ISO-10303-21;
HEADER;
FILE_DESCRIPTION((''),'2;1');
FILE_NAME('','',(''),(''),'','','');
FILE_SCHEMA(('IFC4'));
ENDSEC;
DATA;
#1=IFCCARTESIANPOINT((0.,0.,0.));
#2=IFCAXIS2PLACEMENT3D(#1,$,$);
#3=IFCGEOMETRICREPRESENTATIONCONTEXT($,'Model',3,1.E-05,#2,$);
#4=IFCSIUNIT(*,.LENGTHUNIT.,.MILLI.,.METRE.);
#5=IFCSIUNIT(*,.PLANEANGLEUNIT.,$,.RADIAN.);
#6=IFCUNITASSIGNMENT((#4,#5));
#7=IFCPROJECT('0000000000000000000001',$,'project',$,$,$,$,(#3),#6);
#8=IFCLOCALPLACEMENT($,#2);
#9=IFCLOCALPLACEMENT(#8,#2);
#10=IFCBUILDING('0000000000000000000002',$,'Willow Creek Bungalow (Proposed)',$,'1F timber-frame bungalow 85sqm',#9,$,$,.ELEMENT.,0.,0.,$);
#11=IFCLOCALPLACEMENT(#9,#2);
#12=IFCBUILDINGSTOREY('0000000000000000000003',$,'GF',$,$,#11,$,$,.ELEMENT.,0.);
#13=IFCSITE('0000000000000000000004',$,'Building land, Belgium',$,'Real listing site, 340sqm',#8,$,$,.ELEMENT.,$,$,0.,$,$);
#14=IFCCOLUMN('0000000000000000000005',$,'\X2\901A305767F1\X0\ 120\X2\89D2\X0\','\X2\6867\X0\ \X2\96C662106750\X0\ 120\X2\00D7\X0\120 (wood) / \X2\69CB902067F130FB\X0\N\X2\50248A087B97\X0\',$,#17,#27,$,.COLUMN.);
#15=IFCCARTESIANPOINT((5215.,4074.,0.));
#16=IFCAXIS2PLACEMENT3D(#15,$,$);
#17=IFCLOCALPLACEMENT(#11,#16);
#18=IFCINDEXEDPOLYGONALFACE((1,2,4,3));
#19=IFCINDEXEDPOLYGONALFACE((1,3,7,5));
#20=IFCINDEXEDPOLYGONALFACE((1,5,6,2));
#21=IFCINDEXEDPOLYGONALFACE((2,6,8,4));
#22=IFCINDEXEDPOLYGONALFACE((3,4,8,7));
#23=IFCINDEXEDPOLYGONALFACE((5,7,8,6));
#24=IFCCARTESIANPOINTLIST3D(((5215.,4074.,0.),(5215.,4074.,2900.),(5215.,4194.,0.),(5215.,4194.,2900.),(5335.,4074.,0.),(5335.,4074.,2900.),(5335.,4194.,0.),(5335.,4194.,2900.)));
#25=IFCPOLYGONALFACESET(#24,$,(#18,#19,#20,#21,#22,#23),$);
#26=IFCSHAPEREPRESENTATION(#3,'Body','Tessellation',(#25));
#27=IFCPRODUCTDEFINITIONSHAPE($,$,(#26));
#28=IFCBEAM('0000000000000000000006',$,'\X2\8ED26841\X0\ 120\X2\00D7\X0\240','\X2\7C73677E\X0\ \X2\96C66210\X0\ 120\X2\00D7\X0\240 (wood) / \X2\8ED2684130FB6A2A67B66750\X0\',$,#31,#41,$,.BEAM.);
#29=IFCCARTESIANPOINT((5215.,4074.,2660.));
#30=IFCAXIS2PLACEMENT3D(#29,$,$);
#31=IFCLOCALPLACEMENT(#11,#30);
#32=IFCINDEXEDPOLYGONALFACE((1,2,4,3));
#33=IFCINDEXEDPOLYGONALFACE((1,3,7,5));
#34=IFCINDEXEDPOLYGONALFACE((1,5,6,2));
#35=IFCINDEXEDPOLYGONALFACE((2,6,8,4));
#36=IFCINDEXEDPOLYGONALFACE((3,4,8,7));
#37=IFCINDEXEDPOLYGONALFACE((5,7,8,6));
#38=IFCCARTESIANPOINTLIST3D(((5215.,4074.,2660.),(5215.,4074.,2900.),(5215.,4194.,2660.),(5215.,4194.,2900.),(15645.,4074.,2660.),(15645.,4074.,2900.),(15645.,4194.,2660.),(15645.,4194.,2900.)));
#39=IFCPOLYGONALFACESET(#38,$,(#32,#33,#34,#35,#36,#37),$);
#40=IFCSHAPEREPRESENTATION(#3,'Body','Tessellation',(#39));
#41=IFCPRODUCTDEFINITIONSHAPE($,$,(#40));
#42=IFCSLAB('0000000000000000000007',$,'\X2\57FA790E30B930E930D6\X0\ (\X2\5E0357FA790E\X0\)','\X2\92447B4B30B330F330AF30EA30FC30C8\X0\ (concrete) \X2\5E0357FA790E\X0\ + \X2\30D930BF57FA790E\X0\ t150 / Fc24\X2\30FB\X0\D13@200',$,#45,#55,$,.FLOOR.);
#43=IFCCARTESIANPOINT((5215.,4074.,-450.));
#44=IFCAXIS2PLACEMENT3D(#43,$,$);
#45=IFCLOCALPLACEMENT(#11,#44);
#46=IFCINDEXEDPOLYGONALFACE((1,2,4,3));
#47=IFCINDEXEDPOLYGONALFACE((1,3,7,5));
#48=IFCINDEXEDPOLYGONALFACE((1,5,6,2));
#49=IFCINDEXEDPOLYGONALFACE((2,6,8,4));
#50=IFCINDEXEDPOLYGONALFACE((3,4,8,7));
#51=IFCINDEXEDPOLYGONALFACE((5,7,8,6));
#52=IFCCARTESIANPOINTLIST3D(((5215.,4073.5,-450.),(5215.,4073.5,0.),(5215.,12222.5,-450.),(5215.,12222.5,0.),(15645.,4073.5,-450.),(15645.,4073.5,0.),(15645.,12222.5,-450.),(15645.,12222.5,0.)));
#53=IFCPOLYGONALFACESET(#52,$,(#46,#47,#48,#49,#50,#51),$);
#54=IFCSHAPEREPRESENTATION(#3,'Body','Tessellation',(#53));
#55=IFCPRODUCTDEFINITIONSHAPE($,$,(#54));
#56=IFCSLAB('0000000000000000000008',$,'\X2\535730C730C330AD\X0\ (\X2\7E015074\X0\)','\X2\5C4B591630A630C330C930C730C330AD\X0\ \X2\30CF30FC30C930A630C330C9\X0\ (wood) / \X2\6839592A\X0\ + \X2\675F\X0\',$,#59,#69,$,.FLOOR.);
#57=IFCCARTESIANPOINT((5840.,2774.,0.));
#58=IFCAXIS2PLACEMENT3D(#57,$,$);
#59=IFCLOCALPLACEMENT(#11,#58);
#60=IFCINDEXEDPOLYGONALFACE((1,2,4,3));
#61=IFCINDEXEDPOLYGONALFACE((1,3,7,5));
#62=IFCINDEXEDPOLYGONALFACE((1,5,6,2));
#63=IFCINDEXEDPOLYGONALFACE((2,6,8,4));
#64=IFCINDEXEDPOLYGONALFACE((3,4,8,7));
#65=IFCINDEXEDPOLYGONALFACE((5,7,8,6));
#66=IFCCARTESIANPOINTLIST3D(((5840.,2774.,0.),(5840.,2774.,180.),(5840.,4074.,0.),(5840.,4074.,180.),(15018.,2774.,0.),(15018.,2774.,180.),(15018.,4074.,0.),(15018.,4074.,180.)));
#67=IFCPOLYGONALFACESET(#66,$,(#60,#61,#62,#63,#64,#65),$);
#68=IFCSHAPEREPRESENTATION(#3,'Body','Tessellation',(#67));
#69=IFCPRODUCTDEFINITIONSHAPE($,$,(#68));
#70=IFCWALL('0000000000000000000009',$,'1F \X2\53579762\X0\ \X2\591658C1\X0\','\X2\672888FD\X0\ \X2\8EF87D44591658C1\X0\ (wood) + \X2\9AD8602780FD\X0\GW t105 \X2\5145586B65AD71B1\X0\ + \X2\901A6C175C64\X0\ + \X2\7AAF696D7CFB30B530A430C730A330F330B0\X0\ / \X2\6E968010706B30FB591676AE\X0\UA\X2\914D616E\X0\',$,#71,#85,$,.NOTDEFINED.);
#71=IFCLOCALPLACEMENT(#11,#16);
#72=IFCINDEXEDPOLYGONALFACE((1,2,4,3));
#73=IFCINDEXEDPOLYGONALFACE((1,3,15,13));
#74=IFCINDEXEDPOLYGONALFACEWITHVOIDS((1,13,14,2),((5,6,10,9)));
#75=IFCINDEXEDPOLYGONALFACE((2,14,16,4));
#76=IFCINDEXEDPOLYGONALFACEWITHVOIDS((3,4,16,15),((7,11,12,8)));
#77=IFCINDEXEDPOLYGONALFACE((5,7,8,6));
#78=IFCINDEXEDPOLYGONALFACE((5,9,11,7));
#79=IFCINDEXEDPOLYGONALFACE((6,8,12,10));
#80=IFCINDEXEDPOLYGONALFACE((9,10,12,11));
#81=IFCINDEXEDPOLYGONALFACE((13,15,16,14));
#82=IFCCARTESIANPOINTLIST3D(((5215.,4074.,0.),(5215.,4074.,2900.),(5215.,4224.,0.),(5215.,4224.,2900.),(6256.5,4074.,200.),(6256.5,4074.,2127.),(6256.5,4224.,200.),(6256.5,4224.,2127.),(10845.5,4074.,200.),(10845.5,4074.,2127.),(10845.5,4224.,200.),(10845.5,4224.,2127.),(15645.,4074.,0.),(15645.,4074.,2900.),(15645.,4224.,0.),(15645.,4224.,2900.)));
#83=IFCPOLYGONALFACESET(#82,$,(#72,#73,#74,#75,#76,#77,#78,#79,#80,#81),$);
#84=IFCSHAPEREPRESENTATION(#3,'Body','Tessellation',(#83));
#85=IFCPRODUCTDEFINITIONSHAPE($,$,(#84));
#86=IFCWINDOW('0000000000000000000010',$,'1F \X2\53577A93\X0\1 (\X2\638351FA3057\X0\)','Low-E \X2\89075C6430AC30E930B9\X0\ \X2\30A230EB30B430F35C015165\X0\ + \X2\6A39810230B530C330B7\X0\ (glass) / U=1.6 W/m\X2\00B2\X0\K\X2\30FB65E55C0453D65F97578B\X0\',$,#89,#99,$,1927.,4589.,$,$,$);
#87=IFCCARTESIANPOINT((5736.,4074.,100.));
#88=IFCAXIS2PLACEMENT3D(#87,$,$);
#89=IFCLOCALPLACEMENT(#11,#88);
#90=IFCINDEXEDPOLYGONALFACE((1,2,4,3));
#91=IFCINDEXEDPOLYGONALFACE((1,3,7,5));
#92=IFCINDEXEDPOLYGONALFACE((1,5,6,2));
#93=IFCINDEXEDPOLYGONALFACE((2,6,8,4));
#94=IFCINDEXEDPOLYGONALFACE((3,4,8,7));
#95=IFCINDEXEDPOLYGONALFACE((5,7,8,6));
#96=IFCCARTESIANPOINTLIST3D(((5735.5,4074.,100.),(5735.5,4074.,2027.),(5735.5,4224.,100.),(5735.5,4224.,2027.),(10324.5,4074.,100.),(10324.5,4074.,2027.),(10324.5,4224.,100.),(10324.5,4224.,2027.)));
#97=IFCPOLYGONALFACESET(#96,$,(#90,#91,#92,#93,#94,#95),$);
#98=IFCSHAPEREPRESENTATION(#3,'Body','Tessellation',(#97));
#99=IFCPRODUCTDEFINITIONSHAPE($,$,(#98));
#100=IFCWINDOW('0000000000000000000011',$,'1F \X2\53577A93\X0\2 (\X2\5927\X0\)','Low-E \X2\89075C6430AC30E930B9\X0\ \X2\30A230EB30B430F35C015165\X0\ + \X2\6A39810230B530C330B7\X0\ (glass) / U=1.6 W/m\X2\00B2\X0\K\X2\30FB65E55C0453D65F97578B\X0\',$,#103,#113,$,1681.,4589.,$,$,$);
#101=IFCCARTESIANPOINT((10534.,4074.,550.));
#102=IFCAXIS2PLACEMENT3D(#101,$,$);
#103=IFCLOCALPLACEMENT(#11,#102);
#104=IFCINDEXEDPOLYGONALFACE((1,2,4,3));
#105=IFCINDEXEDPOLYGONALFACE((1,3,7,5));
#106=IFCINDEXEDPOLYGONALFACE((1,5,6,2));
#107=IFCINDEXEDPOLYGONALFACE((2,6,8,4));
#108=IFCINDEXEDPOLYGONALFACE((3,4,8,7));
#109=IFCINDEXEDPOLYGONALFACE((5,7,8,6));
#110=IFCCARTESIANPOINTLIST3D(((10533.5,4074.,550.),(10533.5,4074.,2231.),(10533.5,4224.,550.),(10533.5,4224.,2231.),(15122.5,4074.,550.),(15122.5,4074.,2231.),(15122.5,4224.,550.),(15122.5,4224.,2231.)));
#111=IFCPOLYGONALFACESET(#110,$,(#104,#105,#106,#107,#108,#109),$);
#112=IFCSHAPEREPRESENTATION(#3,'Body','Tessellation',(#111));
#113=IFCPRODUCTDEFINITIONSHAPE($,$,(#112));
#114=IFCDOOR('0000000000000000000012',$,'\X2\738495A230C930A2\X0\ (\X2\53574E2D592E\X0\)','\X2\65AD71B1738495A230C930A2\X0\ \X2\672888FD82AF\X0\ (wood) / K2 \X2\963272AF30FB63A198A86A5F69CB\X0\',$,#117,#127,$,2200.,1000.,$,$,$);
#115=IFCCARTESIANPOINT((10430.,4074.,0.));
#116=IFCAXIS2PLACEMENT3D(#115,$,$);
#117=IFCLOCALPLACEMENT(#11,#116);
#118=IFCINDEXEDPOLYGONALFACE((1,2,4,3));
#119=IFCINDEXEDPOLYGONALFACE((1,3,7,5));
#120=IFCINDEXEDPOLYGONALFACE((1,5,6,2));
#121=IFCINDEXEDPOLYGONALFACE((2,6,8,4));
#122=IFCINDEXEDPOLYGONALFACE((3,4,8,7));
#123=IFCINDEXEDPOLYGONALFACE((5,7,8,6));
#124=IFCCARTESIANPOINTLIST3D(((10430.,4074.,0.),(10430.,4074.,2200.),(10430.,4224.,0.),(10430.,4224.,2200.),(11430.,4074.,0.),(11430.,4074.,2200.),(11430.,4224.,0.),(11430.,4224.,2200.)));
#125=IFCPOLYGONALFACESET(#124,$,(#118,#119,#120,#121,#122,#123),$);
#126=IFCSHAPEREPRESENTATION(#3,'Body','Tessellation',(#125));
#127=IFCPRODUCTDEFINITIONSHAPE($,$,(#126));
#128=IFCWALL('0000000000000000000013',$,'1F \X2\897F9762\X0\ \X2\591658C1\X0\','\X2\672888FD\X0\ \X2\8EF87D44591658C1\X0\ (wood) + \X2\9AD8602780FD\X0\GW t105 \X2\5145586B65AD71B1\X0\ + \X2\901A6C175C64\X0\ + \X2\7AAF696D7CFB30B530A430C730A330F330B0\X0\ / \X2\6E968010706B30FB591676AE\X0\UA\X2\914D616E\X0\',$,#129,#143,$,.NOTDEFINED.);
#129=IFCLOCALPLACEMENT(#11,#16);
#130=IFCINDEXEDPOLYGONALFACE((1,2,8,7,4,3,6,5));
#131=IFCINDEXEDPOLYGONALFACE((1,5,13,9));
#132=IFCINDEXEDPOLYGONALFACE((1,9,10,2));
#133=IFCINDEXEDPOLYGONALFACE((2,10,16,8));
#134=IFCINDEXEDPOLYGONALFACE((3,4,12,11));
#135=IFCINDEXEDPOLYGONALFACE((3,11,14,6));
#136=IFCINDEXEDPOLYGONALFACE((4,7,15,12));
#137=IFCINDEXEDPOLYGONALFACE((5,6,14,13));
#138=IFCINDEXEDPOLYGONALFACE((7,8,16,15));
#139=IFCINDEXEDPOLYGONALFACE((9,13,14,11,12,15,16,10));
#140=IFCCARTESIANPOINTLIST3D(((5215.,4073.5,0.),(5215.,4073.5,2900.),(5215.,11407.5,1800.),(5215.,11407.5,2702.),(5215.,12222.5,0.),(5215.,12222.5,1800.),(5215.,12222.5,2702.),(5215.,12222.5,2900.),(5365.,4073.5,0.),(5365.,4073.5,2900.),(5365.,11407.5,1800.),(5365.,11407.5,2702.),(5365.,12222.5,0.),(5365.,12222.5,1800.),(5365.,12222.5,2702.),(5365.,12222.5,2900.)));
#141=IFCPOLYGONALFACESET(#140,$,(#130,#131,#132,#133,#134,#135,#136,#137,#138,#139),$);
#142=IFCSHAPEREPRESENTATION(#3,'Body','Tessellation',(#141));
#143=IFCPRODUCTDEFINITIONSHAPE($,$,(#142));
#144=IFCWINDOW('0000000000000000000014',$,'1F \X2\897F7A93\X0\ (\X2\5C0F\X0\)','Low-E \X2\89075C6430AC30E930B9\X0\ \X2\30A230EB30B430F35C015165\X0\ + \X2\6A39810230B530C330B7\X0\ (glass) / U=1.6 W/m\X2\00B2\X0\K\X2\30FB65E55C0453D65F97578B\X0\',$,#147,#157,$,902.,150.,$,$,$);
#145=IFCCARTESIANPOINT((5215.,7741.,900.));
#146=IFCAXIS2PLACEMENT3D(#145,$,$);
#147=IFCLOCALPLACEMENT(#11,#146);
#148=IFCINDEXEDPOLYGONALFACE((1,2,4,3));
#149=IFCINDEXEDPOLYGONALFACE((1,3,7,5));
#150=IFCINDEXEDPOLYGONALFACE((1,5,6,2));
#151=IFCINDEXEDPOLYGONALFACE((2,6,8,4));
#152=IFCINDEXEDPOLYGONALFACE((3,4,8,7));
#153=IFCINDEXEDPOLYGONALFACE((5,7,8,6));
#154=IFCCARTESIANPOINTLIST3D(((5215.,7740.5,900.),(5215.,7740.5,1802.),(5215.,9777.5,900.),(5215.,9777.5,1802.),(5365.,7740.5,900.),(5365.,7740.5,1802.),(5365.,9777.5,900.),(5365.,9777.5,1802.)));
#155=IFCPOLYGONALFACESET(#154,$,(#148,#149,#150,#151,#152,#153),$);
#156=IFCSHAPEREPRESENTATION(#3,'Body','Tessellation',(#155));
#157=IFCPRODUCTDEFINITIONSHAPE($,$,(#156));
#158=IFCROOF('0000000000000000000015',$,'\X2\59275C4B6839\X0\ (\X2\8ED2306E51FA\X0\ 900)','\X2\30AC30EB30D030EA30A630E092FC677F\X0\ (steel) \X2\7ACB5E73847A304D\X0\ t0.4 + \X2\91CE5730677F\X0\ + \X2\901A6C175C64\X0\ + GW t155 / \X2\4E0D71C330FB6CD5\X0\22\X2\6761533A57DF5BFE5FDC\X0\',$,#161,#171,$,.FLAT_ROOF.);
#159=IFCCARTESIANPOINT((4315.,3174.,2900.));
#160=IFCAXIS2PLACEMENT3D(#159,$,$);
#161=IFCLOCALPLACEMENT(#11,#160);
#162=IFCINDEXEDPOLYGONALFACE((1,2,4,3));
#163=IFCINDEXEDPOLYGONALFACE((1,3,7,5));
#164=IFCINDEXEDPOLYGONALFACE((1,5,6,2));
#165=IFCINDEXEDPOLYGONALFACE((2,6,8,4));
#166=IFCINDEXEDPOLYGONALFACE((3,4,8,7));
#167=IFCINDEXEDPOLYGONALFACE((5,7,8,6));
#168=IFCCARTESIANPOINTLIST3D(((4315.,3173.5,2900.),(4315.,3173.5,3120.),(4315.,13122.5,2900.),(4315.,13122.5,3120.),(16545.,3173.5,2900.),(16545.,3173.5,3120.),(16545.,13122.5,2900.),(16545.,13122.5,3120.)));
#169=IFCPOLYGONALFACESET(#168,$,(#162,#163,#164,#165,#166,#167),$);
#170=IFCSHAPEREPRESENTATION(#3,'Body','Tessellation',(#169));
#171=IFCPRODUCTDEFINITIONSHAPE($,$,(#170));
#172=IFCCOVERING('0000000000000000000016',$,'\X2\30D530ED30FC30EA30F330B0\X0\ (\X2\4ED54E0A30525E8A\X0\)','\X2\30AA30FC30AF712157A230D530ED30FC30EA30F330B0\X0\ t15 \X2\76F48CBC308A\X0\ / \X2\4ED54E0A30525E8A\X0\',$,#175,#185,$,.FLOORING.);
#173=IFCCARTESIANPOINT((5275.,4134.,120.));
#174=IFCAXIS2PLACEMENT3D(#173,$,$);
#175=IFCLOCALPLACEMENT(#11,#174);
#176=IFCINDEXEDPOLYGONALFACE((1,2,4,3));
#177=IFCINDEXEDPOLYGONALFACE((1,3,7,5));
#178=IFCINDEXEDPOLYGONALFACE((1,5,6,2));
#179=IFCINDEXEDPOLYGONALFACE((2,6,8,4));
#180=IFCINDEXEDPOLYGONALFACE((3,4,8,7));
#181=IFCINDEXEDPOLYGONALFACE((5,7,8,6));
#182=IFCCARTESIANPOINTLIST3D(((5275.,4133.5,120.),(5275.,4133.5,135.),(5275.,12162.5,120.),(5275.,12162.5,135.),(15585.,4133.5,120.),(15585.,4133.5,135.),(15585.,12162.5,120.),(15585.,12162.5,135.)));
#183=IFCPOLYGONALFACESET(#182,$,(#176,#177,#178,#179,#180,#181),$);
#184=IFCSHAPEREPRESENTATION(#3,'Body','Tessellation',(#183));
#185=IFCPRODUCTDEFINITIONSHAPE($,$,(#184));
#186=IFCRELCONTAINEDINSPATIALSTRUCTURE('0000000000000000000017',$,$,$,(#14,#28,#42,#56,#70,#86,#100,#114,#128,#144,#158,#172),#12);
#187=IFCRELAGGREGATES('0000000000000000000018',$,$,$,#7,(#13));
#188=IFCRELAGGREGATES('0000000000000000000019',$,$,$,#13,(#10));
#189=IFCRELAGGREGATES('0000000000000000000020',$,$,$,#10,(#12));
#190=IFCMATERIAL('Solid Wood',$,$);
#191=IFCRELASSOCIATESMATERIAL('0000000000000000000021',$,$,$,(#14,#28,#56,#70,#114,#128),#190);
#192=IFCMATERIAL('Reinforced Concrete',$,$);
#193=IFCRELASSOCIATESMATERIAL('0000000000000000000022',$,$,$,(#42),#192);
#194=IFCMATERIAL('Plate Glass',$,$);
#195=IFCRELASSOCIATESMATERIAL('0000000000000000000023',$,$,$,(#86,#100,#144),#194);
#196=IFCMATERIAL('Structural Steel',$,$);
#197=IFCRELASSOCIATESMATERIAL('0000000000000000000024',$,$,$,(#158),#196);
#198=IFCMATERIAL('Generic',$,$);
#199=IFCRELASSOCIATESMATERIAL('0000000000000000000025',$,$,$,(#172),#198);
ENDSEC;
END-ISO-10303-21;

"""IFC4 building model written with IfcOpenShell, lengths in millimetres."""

from ifc_helpers import new_model, si_unit, frame, frame_2d, origin, place, context, project, spatial, rectangle, extrude, material, element, fill, save


model = new_model("IFC4")

# Units and contexts
model_context = context("Model", 3, precision=1e-05, world=origin())
ifc_project = project(units=[si_unit("LENGTHUNIT", "METRE", prefix="MILLI"), si_unit("PLANEANGLEUNIT", "RADIAN")], contexts=[model_context])

# Site, building, storey
site_placement = place(None, origin())
site = spatial("IfcSite", under=ifc_project, at=site_placement, Name="Building land, Belgium", ObjectType="Real listing site, 340sqm", CompositionType="ELEMENT", RefElevation=0.0)
building_placement = place(site_placement, origin())
building = spatial("IfcBuilding", under=site, at=building_placement, Name="Willow Creek Bungalow (Proposed)", ObjectType="1F timber-frame bungalow 85sqm", CompositionType="ELEMENT", ElevationOfRefHeight=0.0, ElevationOfTerrain=0.0)
storey_placement = place(building_placement, origin())
storey = spatial("IfcBuildingStorey", under=building, at=storey_placement, Name="GF", CompositionType="ELEMENT", Elevation=0.0)

# Column
ifc_material_1 = material(Name="Solid Wood")
column_1_placement = place(storey_placement, frame((5215.0, 4074.0, 0.0)))
element("IfcColumn", 1, at=column_1_placement, inside=storey, material=ifc_material_1, Name="通し柱 120角", Description="桧 集成材 120×120 (wood) / 構造柱・N値計算", PredefinedType="COLUMN", context=model_context, shape_type="SweptSolid", body=[
    extrude(rectangle(XDim=120.0, YDim=120.0, at=frame_2d((60.0, 60.0))), frame((5215.0, 4074.0, 0.0)), (0.0, 0.0, 1.0), 2900.0),
])

# Beam
beam_1_placement = place(storey_placement, frame((5215.0, 4074.0, 2660.0)))
element("IfcBeam", 2, at=beam_1_placement, inside=storey, material=ifc_material_1, Name="軒桁 120×240", Description="米松 集成 120×240 (wood) / 軒桁・横架材", PredefinedType="BEAM", context=model_context, shape_type="SweptSolid", body=[
    extrude(rectangle(XDim=10430.0, YDim=120.0, at=frame_2d((5215.0, 60.0))), frame((5215.0, 4074.0, 2660.0)), (0.0, 0.0, 1.0), 240.0),
])

# Slabs
ifc_material_2 = material(Name="Reinforced Concrete")
slab_1_placement = place(storey_placement, frame((5215.0, 4074.0, -450.0)))
element("IfcSlab", 3, at=slab_1_placement, inside=storey, material=ifc_material_2, Name="基礎スラブ (布基礎)", Description="鉄筋コンクリート (concrete) 布基礎 + ベタ基礎 t150 / Fc24・D13@200", PredefinedType="FLOOR", context=model_context, shape_type="SweptSolid", body=[
    extrude(rectangle(XDim=10430.0, YDim=8149.0, at=frame_2d((5215.0, 4074.0))), frame((5215.0, 4074.0, -450.0)), (0.0, 0.0, 1.0), 450.0),
])
slab_2_placement = place(storey_placement, frame((5840.0, 2774.0, 0.0)))
element("IfcSlab", 4, at=slab_2_placement, inside=storey, material=ifc_material_1, Name="南デッキ (縁側)", Description="屋外ウッドデッキ ハードウッド (wood) / 根太 + 束", PredefinedType="FLOOR", context=model_context, shape_type="SweptSolid", body=[
    extrude(rectangle(XDim=9178.0, YDim=1300.0, at=frame_2d((4589.0, 650.0))), frame((5840.0, 2774.0, 0.0)), (0.0, 0.0, 1.0), 180.0),
])

# Wall, openings, windows, door
wall_1_placement = place(storey_placement, frame((5215.0, 4074.0, 0.0)))
wall_1 = element("IfcWall", 5, at=wall_1_placement, inside=storey, material=ifc_material_1, Name="1F 南面 外壁", Description="木製 軸組外壁 (wood) + 高性能GW t105 充填断熱 + 通気層 + 窯業系サイディング / 準耐火・外皮UA配慮", PredefinedType="NOTDEFINED", context=model_context, shape_type="SweptSolid", body=[
    extrude(rectangle(XDim=10430.0, YDim=150.0, at=frame_2d((5215.0, 75.0))), frame((5215.0, 4074.0, 0.0)), (0.0, 0.0, 1.0), 2900.0),
])
opening_1_placement = place(storey_placement, frame((5736.0, 4074.0, 100.0)))
opening_1 = element("IfcOpeningElement", 6, at=opening_1_placement, cuts=wall_1, PredefinedType="NOTDEFINED", context=model_context, shape_type="SweptSolid", body=[
    extrude(rectangle(XDim=4589.0, YDim=150.0, at=frame_2d((2294.0, 75.0))), frame((5736.0, 4074.0, 100.0)), (0.0, 0.0, 1.0), 1927.0),
])
opening_2_placement = place(storey_placement, frame((10534.0, 4074.0, 550.0)))
opening_2 = element("IfcOpeningElement", 7, at=opening_2_placement, cuts=wall_1, PredefinedType="NOTDEFINED", context=model_context, shape_type="SweptSolid", body=[
    extrude(rectangle(XDim=4589.0, YDim=150.0, at=frame_2d((2294.0, 75.0))), frame((10534.0, 4074.0, 550.0)), (0.0, 0.0, 1.0), 1681.0),
])
opening_3_placement = place(storey_placement, frame((10430.0, 4074.0, 0.0)))
opening_3 = element("IfcOpeningElement", 8, at=opening_3_placement, cuts=wall_1, PredefinedType="NOTDEFINED", context=model_context, shape_type="SweptSolid", body=[
    extrude(rectangle(XDim=1000.0, YDim=150.0, at=frame_2d((500.0, 75.0))), frame((10430.0, 4074.0, 0.0)), (0.0, 0.0, 1.0), 2200.0),
])
ifc_material_3 = material(Name="Plate Glass")
window_1_placement = place(storey_placement, frame((5736.0, 4074.0, 100.0)))
window_1 = element("IfcWindow", 9, at=window_1_placement, inside=storey, material=ifc_material_3, Name="1F 南窓1 (掃出し)", Description="Low-E 複層ガラス アルゴン封入 + 樹脂サッシ (glass) / U=1.6 W/m²K・日射取得型", OverallHeight=1927.0, OverallWidth=4589.0, context=model_context, shape_type="SweptSolid", body=[
    extrude(rectangle(XDim=4589.0, YDim=150.0, at=frame_2d((2294.0, 75.0))), frame((5736.0, 4074.0, 100.0)), (0.0, 0.0, 1.0), 1927.0),
])
fill(opening_1, window_1)
window_2_placement = place(storey_placement, frame((10534.0, 4074.0, 550.0)))
window_2 = element("IfcWindow", 10, at=window_2_placement, inside=storey, material=ifc_material_3, Name="1F 南窓2 (大)", Description="Low-E 複層ガラス アルゴン封入 + 樹脂サッシ (glass) / U=1.6 W/m²K・日射取得型", OverallHeight=1681.0, OverallWidth=4589.0, context=model_context, shape_type="SweptSolid", body=[
    extrude(rectangle(XDim=4589.0, YDim=150.0, at=frame_2d((2294.0, 75.0))), frame((10534.0, 4074.0, 550.0)), (0.0, 0.0, 1.0), 1681.0),
])
fill(opening_2, window_2)
door_placement = place(storey_placement, frame((10430.0, 4074.0, 0.0)))
door = element("IfcDoor", 11, at=door_placement, inside=storey, material=ifc_material_1, Name="玄関ドア (南中央)", Description="断熱玄関ドア 木製芯 (wood) / K2 防犯・採風機構", OverallHeight=2200.0, OverallWidth=1000.0, context=model_context, shape_type="SweptSolid", body=[
    extrude(rectangle(XDim=1000.0, YDim=150.0, at=frame_2d((500.0, 75.0))), frame((10430.0, 4074.0, 0.0)), (0.0, 0.0, 1.0), 2200.0),
])
fill(opening_3, door)

# Wall, opening, window
wall_2_placement = place(storey_placement, frame((5215.0, 4074.0, 0.0)))
wall_2 = element("IfcWall", 12, at=wall_2_placement, inside=storey, material=ifc_material_1, Name="1F 西面 外壁", Description="木製 軸組外壁 (wood) + 高性能GW t105 充填断熱 + 通気層 + 窯業系サイディング / 準耐火・外皮UA配慮", PredefinedType="NOTDEFINED", context=model_context, shape_type="SweptSolid", body=[
    extrude(rectangle(XDim=150.0, YDim=8149.0, at=frame_2d((75.0, 4074.0))), frame((5215.0, 4074.0, 0.0)), (0.0, 0.0, 1.0), 2900.0),
])
opening_4_placement = place(storey_placement, frame((5215.0, 7741.0, 900.0)))
opening_4 = element("IfcOpeningElement", 13, at=opening_4_placement, cuts=wall_2, PredefinedType="NOTDEFINED", context=model_context, shape_type="SweptSolid", body=[
    extrude(rectangle(XDim=150.0, YDim=2037.0, at=frame_2d((75.0, 1018.0))), frame((5215.0, 7741.0, 900.0)), (0.0, 0.0, 1.0), 902.0),
])
window_3_placement = place(storey_placement, frame((5215.0, 7741.0, 900.0)))
window_3 = element("IfcWindow", 14, at=window_3_placement, inside=storey, material=ifc_material_3, Name="1F 西窓 (小)", Description="Low-E 複層ガラス アルゴン封入 + 樹脂サッシ (glass) / U=1.6 W/m²K・日射取得型", OverallHeight=902.0, OverallWidth=150.0, context=model_context, shape_type="SweptSolid", body=[
    extrude(rectangle(XDim=150.0, YDim=2037.0, at=frame_2d((75.0, 1018.0))), frame((5215.0, 7741.0, 900.0)), (0.0, 0.0, 1.0), 902.0),
])
fill(opening_4, window_3)

# Roof
ifc_material_4 = material(Name="Structural Steel")
roof_placement = place(storey_placement, frame((4315.0, 3174.0, 2900.0)))
element("IfcRoof", 15, at=roof_placement, inside=storey, material=ifc_material_4, Name="大屋根 (軒の出 900)", Description="ガルバリウム鋼板 (steel) 立平葺き t0.4 + 野地板 + 通気層 + GW t155 / 不燃・法22条区域対応", PredefinedType="FLAT_ROOF", context=model_context, shape_type="SweptSolid", body=[
    extrude(rectangle(XDim=12230.0, YDim=9949.0, at=frame_2d((6115.0, 4974.0))), frame((4315.0, 3174.0, 2900.0)), (0.0, 0.0, 1.0), 220.0),
])

# Covering
ifc_material_5 = material(Name="Generic")
covering_1_placement = place(storey_placement, frame((5275.0, 4134.0, 120.0)))
element("IfcCovering", 16, at=covering_1_placement, inside=storey, material=ifc_material_5, Name="フローリング (仕上げ床)", Description="オーク無垢フローリング t15 直貼り / 仕上げ床", PredefinedType="FLOORING", context=model_context, shape_type="SweptSolid", body=[
    extrude(rectangle(XDim=10310.0, YDim=8029.0, at=frame_2d((5155.0, 4014.0))), frame((5275.0, 4134.0, 120.0)), (0.0, 0.0, 1.0), 15.0),
])

save(model, "model.ifc")
